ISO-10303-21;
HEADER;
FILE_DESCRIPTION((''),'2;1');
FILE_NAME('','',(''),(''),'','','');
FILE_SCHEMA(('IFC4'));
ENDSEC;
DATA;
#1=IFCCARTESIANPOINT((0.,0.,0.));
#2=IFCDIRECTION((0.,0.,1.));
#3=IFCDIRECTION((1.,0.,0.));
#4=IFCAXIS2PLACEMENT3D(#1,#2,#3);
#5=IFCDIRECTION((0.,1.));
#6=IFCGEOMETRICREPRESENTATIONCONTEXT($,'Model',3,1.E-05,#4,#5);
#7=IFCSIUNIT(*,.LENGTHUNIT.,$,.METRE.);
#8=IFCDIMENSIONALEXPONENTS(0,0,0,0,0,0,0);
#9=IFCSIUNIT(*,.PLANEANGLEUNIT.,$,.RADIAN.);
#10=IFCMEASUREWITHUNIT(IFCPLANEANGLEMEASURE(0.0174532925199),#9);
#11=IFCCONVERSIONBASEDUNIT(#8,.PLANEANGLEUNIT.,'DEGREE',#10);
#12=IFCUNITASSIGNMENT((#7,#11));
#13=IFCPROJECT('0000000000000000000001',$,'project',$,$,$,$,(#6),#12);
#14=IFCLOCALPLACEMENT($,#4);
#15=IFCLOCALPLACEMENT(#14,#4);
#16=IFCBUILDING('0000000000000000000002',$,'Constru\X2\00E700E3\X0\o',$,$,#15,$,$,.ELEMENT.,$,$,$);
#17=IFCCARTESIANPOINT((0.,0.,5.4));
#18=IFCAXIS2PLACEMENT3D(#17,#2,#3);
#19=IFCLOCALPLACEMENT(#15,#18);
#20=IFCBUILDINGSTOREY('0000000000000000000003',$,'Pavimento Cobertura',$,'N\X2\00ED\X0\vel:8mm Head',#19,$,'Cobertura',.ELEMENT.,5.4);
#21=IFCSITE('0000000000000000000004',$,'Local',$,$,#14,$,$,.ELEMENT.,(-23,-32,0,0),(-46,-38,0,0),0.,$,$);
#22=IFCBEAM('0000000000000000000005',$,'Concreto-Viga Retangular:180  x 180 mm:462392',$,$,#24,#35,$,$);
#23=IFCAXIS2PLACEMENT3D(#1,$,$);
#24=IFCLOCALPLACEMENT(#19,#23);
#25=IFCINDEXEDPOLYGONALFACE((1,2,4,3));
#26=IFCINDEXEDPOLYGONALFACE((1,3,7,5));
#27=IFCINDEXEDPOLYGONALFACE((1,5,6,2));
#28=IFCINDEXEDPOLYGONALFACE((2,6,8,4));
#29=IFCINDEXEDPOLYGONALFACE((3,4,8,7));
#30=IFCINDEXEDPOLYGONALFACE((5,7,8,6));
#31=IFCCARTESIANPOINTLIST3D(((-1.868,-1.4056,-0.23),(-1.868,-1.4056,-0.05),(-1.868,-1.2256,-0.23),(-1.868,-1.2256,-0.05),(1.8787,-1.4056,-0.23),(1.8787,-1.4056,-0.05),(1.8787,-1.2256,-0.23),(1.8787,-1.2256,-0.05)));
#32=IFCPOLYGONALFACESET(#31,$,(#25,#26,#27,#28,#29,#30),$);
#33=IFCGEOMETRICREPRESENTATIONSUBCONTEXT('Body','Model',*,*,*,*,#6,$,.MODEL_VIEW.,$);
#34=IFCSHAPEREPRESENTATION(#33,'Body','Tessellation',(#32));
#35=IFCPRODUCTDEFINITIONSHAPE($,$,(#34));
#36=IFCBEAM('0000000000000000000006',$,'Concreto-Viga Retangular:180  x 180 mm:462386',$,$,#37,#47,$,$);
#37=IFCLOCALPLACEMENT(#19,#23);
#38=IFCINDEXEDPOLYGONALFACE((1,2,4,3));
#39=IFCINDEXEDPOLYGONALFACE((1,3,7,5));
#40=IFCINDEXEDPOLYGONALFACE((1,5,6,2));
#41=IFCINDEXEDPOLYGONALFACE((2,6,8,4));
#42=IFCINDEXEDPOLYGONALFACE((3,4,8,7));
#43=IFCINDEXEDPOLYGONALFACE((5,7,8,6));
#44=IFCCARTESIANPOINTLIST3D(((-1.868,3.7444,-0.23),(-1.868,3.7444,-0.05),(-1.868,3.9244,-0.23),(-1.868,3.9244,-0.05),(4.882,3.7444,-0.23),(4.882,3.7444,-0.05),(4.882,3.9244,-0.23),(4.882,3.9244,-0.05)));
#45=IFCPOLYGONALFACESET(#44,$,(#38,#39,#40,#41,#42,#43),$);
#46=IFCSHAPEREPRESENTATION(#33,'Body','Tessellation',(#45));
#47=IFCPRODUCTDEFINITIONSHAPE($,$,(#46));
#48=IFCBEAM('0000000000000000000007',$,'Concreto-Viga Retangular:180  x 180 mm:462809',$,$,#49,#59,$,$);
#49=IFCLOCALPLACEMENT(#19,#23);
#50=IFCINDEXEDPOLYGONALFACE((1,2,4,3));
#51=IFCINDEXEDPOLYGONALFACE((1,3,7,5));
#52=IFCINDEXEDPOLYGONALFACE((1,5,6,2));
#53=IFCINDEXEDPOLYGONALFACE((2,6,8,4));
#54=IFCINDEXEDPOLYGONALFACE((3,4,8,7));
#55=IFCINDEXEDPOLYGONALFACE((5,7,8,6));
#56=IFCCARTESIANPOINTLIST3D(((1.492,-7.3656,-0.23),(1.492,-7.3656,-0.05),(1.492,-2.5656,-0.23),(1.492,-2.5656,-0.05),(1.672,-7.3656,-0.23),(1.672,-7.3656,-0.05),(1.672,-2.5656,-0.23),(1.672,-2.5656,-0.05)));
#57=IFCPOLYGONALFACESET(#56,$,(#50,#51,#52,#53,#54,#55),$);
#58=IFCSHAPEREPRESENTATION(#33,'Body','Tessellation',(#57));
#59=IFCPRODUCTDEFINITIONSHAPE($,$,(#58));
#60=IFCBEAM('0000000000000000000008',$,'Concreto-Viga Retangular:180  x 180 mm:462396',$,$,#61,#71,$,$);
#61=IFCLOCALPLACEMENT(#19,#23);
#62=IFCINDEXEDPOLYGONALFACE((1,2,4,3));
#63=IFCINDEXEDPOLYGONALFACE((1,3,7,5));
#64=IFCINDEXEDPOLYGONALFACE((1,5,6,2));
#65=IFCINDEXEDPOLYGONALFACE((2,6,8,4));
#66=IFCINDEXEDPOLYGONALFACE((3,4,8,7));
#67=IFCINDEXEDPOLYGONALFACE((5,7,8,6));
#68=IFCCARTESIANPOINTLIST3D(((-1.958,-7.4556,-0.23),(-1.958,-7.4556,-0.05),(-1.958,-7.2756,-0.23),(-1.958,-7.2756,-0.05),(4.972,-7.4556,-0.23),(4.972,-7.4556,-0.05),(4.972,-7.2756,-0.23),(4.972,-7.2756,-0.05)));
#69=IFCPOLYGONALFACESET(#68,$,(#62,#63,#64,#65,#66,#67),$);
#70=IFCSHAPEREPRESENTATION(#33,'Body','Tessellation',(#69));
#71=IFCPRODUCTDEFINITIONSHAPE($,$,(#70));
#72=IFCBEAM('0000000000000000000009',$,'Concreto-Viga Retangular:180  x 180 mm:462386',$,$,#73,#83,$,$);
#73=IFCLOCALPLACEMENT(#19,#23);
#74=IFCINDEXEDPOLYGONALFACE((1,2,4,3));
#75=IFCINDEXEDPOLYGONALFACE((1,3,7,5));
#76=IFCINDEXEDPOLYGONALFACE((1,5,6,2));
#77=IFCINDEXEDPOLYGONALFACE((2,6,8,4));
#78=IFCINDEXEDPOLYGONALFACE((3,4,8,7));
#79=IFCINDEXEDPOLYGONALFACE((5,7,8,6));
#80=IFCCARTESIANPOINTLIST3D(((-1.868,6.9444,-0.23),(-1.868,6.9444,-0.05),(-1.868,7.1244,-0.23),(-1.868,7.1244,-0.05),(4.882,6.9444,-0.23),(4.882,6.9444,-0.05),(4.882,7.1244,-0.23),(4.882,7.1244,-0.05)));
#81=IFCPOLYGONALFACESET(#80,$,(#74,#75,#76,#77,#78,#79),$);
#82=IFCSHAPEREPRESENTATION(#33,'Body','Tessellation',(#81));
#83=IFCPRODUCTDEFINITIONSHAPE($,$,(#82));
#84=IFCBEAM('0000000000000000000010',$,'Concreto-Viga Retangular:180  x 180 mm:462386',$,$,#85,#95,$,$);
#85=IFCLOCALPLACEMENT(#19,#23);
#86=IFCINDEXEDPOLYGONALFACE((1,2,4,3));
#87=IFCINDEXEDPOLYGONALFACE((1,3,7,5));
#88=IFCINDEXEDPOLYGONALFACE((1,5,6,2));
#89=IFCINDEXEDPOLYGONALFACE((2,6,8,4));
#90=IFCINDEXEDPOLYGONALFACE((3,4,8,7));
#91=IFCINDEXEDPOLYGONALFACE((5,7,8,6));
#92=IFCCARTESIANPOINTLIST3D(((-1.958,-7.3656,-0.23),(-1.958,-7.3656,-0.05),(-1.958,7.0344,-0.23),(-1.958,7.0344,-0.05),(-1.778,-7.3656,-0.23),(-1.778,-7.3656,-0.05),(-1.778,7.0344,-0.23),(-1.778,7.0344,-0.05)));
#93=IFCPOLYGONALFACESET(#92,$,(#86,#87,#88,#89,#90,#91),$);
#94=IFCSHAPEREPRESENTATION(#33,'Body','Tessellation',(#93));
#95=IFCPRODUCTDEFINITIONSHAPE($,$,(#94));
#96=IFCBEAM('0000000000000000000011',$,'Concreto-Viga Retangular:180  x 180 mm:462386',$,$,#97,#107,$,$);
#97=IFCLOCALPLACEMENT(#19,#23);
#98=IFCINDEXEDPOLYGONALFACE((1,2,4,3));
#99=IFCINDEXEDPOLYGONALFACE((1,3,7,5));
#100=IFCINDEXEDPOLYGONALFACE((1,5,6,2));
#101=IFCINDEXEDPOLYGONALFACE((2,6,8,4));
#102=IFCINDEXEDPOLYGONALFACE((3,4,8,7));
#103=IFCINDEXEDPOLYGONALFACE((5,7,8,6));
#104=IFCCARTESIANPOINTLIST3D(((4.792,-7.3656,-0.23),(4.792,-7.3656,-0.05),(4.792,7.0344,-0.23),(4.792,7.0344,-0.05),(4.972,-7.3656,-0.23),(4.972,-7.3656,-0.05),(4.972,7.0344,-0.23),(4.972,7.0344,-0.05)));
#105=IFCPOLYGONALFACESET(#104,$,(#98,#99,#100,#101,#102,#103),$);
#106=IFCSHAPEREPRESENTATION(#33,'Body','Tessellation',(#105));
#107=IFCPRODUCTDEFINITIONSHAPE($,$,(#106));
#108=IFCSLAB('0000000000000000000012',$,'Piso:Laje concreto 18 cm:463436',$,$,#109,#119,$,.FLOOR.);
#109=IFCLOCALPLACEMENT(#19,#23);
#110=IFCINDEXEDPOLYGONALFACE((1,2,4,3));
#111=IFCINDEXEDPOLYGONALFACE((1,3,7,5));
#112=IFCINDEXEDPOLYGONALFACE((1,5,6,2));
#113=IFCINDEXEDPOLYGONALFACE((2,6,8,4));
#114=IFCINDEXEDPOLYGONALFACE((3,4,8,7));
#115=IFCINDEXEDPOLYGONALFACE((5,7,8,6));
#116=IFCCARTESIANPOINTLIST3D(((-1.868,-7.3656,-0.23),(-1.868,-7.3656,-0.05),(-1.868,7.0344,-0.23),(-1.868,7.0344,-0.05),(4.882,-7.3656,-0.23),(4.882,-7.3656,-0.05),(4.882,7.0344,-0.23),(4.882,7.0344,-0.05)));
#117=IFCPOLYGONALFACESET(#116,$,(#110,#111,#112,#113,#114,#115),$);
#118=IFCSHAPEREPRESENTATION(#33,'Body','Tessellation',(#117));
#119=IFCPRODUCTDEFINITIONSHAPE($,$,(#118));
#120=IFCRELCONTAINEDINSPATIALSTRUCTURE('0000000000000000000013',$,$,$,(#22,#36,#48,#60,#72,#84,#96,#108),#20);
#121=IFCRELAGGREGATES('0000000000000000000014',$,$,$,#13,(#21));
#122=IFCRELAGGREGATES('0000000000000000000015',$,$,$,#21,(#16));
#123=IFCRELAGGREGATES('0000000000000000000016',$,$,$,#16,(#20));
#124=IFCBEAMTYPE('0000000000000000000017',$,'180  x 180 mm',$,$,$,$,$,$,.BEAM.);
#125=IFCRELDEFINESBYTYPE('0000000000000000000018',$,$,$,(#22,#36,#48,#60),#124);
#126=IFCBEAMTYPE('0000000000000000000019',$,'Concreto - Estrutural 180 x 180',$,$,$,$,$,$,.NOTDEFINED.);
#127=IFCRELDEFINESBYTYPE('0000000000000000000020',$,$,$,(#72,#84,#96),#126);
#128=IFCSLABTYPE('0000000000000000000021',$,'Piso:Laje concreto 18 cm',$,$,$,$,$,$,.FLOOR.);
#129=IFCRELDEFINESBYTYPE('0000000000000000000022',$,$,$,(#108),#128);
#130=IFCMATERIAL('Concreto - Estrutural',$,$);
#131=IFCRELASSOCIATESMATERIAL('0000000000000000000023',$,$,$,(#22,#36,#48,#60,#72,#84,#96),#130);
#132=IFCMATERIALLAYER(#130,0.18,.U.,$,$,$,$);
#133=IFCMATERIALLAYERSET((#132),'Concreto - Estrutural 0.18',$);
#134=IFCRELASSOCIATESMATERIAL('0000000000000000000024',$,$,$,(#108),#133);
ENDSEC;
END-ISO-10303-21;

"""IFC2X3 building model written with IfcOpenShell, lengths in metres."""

from ifc_helpers import new_model, entity, si_unit, converted_unit, direction, frame, frame_2d, origin_with_axes, place, context, subcontext, project, spatial, polyline, rectangle, outline, extrude, material, layer, layer_set, layer_usage, type_object, element, save


model = new_model("IFC2X3")

# Units and contexts
model_context = context("Model", 3, precision=1e-05, world=origin_with_axes(), true_north=direction((0.0, 1.0)))
body_context = subcontext(model_context, "Body", "Model", "MODEL_VIEW")
ifc_project = project(units=[si_unit("LENGTHUNIT", "METRE"), converted_unit("PLANEANGLEUNIT", "DEGREE", entity("IfcPlaneAngleMeasure", 0.0174532925199), si_unit("PLANEANGLEUNIT", "RADIAN"), dimensions=[0, 0, 0, 0, 0, 0, 0])], contexts=[model_context])

# Site, building, storey
site_placement = place(None, origin_with_axes())
site = spatial("IfcSite", under=ifc_project, at=site_placement, Name="Local", CompositionType="ELEMENT", RefLatitude=(-23, -32, 0, 0), RefLongitude=(-46, -38, 0, 0), RefElevation=0.0)
building_placement = place(site_placement, origin_with_axes())
building = spatial("IfcBuilding", under=site, at=building_placement, Name="Construção", CompositionType="ELEMENT")
storey_placement = place(building_placement, frame((0.0, 0.0, 5.4), z_axis=(0.0, 0.0, 1.0), x_axis=(1.0, 0.0, 0.0)))
storey = spatial("IfcBuildingStorey", under=building, at=storey_placement, Name="Pavimento Cobertura", ObjectType="Nível:8mm Head", LongName="Cobertura", CompositionType="ELEMENT", Elevation=5.4)

# Beams
ifc_material = material(Name="Concreto - Estrutural")
beam_type_1 = type_object("IfcBeamType", Name="180  x 180 mm", PredefinedType="BEAM")
beam_1_placement = place(storey_placement, frame((1.8787, -1.3156, -0.05), z_axis=(0.0, 0.0, 1.0), x_axis=(0.0, 1.0, 0.0)))
element("IfcBeam", 1, at=beam_1_placement, inside=storey, type_object=beam_type_1, material=ifc_material, Name="Concreto-Viga Retangular:180  x 180 mm:462392", context=body_context, shape_type="SweptSolid", body=[
    extrude(rectangle(XDim=0.18, YDim=0.18, at=frame_2d((-0.09, 0.0), x_axis=(1.0, 0.0))), frame((0.0, 0.0, 0.0), z_axis=(0.0, 1.0, 0.0), x_axis=(0.0, 0.0, 1.0)), (0.0, 0.0, 1.0), 3.7467),
])
beam_2_placement = place(storey_placement, frame((4.882, 3.8344, -0.05), z_axis=(0.0, 0.0, 1.0), x_axis=(0.0, 1.0, 0.0)))
element("IfcBeam", 2, at=beam_2_placement, inside=storey, type_object=beam_type_1, material=ifc_material, Name="Concreto-Viga Retangular:180  x 180 mm:462386", context=body_context, shape_type="SweptSolid", body=[
    extrude(rectangle(XDim=0.18, YDim=0.18, at=frame_2d((-0.09, 0.0), x_axis=(1.0, 0.0))), frame((0.0, 0.0, 0.0), z_axis=(0.0, 1.0, 0.0), x_axis=(0.0, 0.0, 1.0)), (0.0, 0.0, 1.0), 6.75),
])
beam_3_placement = place(storey_placement, frame((1.582, -7.3656, -0.05), z_axis=(0.0, 0.0, 1.0), x_axis=(1.0, 0.0, 0.0)))
element("IfcBeam", 3, at=beam_3_placement, inside=storey, type_object=beam_type_1, material=ifc_material, Name="Concreto-Viga Retangular:180  x 180 mm:462809", context=body_context, shape_type="SweptSolid", body=[
    extrude(rectangle(XDim=0.18, YDim=0.18, at=frame_2d((-0.09, 0.0), x_axis=(1.0, 0.0))), frame((0.0, 0.0, 0.0), z_axis=(0.0, 1.0, 0.0), x_axis=(0.0, 0.0, 1.0)), (0.0, 0.0, 1.0), 4.8),
])
beam_4_placement = place(storey_placement, frame((4.972, -7.3656, -0.05), z_axis=(0.0, 0.0, 1.0), x_axis=(0.0, 1.0, 0.0)))
element("IfcBeam", 4, at=beam_4_placement, inside=storey, type_object=beam_type_1, material=ifc_material, Name="Concreto-Viga Retangular:180  x 180 mm:462396", context=body_context, shape_type="SweptSolid", body=[
    extrude(rectangle(XDim=0.18, YDim=0.18, at=frame_2d((-0.09, 0.0), x_axis=(1.0, 0.0))), frame((0.0, 0.0, 0.0), z_axis=(0.0, 1.0, 0.0), x_axis=(0.0, 0.0, 1.0)), (0.0, 0.0, 1.0), 6.93),
])
beam_type_2 = type_object("IfcBeamType", Name="Concreto - Estrutural 180 x 180", PredefinedType="NOTDEFINED")
beam_5_placement = place(storey_placement, frame((4.882, 7.0344, -0.05), z_axis=(0.0, 0.0, 1.0), x_axis=(0.0, 1.0, 0.0)))
element("IfcBeam", 5, at=beam_5_placement, inside=storey, type_object=beam_type_2, material=ifc_material, Name="Concreto-Viga Retangular:180  x 180 mm:462386", context=body_context, shape_type="SweptSolid", body=[
    extrude(rectangle(XDim=0.18, YDim=0.18, at=frame_2d((-0.09, 0.0), x_axis=(1.0, 0.0))), frame((0.0, 0.0, 0.0), z_axis=(0.0, 1.0, 0.0), x_axis=(0.0, 0.0, 1.0)), (0.0, 0.0, 1.0), 6.75),
])
for number, where, z_axis, x_axis, name in (
    (6, (-1.868, 7.0344, -0.05), (0.0, 0.0, 1.0), (-1.0, 0.0, 0.0), "Concreto-Viga Retangular:180  x 180 mm:462386"),
    (7, (4.882, 7.0344, -0.05), (0.0, 0.0, 1.0), (-1.0, 0.0, 0.0), "Concreto-Viga Retangular:180  x 180 mm:462386"),
):
    element("IfcBeam", number, at=place(storey_placement, frame(where, z_axis=z_axis, x_axis=x_axis)), inside=storey, type_object=beam_type_2, material=ifc_material, Name=name, context=body_context, shape_type="SweptSolid", body=[
        extrude(rectangle(XDim=0.18, YDim=0.18, at=frame_2d((-0.09, 0.0), x_axis=(1.0, 0.0))), frame((0.0, 0.0, 0.0), z_axis=(0.0, 1.0, 0.0), x_axis=(0.0, 0.0, 1.0)), (0.0, 0.0, 1.0), 14.4),
    ])

# Slab
ifc_layer = layer(ifc_material, 0.18, ventilated="UNKNOWN")
ifc_layer_set = layer_set([ifc_layer], Name="Concreto - Estrutural 0.18")
ifc_layer_usage = layer_usage(ifc_layer_set, "AXIS3", "NEGATIVE", 0.18)
slab_type = type_object("IfcSlabType", Name="Piso:Laje concreto 18 cm", PredefinedType="FLOOR")
slab_placement = place(storey_placement, frame((-1.868, 7.0344, -0.05), z_axis=(0.0, 0.0, 1.0), x_axis=(1.0, 0.0, 0.0)))
element("IfcSlab", 8, at=slab_placement, inside=storey, type_object=slab_type, material=ifc_layer_usage, Name="Piso:Laje concreto 18 cm:463436", PredefinedType="FLOOR", context=body_context, shape_type="SweptSolid", body=[
    extrude(outline(polyline([(0.0, 0.0), (0.0, -14.4), (6.75, -14.4), (6.75, 0.0), (0.0, 0.0)])), frame((0.0, 0.0, -0.18), z_axis=(0.0, 0.0, 1.0), x_axis=(1.0, 0.0, 0.0)), (0.0, 0.0, 1.0), 0.18),
])

save(model, "model.ifc")
